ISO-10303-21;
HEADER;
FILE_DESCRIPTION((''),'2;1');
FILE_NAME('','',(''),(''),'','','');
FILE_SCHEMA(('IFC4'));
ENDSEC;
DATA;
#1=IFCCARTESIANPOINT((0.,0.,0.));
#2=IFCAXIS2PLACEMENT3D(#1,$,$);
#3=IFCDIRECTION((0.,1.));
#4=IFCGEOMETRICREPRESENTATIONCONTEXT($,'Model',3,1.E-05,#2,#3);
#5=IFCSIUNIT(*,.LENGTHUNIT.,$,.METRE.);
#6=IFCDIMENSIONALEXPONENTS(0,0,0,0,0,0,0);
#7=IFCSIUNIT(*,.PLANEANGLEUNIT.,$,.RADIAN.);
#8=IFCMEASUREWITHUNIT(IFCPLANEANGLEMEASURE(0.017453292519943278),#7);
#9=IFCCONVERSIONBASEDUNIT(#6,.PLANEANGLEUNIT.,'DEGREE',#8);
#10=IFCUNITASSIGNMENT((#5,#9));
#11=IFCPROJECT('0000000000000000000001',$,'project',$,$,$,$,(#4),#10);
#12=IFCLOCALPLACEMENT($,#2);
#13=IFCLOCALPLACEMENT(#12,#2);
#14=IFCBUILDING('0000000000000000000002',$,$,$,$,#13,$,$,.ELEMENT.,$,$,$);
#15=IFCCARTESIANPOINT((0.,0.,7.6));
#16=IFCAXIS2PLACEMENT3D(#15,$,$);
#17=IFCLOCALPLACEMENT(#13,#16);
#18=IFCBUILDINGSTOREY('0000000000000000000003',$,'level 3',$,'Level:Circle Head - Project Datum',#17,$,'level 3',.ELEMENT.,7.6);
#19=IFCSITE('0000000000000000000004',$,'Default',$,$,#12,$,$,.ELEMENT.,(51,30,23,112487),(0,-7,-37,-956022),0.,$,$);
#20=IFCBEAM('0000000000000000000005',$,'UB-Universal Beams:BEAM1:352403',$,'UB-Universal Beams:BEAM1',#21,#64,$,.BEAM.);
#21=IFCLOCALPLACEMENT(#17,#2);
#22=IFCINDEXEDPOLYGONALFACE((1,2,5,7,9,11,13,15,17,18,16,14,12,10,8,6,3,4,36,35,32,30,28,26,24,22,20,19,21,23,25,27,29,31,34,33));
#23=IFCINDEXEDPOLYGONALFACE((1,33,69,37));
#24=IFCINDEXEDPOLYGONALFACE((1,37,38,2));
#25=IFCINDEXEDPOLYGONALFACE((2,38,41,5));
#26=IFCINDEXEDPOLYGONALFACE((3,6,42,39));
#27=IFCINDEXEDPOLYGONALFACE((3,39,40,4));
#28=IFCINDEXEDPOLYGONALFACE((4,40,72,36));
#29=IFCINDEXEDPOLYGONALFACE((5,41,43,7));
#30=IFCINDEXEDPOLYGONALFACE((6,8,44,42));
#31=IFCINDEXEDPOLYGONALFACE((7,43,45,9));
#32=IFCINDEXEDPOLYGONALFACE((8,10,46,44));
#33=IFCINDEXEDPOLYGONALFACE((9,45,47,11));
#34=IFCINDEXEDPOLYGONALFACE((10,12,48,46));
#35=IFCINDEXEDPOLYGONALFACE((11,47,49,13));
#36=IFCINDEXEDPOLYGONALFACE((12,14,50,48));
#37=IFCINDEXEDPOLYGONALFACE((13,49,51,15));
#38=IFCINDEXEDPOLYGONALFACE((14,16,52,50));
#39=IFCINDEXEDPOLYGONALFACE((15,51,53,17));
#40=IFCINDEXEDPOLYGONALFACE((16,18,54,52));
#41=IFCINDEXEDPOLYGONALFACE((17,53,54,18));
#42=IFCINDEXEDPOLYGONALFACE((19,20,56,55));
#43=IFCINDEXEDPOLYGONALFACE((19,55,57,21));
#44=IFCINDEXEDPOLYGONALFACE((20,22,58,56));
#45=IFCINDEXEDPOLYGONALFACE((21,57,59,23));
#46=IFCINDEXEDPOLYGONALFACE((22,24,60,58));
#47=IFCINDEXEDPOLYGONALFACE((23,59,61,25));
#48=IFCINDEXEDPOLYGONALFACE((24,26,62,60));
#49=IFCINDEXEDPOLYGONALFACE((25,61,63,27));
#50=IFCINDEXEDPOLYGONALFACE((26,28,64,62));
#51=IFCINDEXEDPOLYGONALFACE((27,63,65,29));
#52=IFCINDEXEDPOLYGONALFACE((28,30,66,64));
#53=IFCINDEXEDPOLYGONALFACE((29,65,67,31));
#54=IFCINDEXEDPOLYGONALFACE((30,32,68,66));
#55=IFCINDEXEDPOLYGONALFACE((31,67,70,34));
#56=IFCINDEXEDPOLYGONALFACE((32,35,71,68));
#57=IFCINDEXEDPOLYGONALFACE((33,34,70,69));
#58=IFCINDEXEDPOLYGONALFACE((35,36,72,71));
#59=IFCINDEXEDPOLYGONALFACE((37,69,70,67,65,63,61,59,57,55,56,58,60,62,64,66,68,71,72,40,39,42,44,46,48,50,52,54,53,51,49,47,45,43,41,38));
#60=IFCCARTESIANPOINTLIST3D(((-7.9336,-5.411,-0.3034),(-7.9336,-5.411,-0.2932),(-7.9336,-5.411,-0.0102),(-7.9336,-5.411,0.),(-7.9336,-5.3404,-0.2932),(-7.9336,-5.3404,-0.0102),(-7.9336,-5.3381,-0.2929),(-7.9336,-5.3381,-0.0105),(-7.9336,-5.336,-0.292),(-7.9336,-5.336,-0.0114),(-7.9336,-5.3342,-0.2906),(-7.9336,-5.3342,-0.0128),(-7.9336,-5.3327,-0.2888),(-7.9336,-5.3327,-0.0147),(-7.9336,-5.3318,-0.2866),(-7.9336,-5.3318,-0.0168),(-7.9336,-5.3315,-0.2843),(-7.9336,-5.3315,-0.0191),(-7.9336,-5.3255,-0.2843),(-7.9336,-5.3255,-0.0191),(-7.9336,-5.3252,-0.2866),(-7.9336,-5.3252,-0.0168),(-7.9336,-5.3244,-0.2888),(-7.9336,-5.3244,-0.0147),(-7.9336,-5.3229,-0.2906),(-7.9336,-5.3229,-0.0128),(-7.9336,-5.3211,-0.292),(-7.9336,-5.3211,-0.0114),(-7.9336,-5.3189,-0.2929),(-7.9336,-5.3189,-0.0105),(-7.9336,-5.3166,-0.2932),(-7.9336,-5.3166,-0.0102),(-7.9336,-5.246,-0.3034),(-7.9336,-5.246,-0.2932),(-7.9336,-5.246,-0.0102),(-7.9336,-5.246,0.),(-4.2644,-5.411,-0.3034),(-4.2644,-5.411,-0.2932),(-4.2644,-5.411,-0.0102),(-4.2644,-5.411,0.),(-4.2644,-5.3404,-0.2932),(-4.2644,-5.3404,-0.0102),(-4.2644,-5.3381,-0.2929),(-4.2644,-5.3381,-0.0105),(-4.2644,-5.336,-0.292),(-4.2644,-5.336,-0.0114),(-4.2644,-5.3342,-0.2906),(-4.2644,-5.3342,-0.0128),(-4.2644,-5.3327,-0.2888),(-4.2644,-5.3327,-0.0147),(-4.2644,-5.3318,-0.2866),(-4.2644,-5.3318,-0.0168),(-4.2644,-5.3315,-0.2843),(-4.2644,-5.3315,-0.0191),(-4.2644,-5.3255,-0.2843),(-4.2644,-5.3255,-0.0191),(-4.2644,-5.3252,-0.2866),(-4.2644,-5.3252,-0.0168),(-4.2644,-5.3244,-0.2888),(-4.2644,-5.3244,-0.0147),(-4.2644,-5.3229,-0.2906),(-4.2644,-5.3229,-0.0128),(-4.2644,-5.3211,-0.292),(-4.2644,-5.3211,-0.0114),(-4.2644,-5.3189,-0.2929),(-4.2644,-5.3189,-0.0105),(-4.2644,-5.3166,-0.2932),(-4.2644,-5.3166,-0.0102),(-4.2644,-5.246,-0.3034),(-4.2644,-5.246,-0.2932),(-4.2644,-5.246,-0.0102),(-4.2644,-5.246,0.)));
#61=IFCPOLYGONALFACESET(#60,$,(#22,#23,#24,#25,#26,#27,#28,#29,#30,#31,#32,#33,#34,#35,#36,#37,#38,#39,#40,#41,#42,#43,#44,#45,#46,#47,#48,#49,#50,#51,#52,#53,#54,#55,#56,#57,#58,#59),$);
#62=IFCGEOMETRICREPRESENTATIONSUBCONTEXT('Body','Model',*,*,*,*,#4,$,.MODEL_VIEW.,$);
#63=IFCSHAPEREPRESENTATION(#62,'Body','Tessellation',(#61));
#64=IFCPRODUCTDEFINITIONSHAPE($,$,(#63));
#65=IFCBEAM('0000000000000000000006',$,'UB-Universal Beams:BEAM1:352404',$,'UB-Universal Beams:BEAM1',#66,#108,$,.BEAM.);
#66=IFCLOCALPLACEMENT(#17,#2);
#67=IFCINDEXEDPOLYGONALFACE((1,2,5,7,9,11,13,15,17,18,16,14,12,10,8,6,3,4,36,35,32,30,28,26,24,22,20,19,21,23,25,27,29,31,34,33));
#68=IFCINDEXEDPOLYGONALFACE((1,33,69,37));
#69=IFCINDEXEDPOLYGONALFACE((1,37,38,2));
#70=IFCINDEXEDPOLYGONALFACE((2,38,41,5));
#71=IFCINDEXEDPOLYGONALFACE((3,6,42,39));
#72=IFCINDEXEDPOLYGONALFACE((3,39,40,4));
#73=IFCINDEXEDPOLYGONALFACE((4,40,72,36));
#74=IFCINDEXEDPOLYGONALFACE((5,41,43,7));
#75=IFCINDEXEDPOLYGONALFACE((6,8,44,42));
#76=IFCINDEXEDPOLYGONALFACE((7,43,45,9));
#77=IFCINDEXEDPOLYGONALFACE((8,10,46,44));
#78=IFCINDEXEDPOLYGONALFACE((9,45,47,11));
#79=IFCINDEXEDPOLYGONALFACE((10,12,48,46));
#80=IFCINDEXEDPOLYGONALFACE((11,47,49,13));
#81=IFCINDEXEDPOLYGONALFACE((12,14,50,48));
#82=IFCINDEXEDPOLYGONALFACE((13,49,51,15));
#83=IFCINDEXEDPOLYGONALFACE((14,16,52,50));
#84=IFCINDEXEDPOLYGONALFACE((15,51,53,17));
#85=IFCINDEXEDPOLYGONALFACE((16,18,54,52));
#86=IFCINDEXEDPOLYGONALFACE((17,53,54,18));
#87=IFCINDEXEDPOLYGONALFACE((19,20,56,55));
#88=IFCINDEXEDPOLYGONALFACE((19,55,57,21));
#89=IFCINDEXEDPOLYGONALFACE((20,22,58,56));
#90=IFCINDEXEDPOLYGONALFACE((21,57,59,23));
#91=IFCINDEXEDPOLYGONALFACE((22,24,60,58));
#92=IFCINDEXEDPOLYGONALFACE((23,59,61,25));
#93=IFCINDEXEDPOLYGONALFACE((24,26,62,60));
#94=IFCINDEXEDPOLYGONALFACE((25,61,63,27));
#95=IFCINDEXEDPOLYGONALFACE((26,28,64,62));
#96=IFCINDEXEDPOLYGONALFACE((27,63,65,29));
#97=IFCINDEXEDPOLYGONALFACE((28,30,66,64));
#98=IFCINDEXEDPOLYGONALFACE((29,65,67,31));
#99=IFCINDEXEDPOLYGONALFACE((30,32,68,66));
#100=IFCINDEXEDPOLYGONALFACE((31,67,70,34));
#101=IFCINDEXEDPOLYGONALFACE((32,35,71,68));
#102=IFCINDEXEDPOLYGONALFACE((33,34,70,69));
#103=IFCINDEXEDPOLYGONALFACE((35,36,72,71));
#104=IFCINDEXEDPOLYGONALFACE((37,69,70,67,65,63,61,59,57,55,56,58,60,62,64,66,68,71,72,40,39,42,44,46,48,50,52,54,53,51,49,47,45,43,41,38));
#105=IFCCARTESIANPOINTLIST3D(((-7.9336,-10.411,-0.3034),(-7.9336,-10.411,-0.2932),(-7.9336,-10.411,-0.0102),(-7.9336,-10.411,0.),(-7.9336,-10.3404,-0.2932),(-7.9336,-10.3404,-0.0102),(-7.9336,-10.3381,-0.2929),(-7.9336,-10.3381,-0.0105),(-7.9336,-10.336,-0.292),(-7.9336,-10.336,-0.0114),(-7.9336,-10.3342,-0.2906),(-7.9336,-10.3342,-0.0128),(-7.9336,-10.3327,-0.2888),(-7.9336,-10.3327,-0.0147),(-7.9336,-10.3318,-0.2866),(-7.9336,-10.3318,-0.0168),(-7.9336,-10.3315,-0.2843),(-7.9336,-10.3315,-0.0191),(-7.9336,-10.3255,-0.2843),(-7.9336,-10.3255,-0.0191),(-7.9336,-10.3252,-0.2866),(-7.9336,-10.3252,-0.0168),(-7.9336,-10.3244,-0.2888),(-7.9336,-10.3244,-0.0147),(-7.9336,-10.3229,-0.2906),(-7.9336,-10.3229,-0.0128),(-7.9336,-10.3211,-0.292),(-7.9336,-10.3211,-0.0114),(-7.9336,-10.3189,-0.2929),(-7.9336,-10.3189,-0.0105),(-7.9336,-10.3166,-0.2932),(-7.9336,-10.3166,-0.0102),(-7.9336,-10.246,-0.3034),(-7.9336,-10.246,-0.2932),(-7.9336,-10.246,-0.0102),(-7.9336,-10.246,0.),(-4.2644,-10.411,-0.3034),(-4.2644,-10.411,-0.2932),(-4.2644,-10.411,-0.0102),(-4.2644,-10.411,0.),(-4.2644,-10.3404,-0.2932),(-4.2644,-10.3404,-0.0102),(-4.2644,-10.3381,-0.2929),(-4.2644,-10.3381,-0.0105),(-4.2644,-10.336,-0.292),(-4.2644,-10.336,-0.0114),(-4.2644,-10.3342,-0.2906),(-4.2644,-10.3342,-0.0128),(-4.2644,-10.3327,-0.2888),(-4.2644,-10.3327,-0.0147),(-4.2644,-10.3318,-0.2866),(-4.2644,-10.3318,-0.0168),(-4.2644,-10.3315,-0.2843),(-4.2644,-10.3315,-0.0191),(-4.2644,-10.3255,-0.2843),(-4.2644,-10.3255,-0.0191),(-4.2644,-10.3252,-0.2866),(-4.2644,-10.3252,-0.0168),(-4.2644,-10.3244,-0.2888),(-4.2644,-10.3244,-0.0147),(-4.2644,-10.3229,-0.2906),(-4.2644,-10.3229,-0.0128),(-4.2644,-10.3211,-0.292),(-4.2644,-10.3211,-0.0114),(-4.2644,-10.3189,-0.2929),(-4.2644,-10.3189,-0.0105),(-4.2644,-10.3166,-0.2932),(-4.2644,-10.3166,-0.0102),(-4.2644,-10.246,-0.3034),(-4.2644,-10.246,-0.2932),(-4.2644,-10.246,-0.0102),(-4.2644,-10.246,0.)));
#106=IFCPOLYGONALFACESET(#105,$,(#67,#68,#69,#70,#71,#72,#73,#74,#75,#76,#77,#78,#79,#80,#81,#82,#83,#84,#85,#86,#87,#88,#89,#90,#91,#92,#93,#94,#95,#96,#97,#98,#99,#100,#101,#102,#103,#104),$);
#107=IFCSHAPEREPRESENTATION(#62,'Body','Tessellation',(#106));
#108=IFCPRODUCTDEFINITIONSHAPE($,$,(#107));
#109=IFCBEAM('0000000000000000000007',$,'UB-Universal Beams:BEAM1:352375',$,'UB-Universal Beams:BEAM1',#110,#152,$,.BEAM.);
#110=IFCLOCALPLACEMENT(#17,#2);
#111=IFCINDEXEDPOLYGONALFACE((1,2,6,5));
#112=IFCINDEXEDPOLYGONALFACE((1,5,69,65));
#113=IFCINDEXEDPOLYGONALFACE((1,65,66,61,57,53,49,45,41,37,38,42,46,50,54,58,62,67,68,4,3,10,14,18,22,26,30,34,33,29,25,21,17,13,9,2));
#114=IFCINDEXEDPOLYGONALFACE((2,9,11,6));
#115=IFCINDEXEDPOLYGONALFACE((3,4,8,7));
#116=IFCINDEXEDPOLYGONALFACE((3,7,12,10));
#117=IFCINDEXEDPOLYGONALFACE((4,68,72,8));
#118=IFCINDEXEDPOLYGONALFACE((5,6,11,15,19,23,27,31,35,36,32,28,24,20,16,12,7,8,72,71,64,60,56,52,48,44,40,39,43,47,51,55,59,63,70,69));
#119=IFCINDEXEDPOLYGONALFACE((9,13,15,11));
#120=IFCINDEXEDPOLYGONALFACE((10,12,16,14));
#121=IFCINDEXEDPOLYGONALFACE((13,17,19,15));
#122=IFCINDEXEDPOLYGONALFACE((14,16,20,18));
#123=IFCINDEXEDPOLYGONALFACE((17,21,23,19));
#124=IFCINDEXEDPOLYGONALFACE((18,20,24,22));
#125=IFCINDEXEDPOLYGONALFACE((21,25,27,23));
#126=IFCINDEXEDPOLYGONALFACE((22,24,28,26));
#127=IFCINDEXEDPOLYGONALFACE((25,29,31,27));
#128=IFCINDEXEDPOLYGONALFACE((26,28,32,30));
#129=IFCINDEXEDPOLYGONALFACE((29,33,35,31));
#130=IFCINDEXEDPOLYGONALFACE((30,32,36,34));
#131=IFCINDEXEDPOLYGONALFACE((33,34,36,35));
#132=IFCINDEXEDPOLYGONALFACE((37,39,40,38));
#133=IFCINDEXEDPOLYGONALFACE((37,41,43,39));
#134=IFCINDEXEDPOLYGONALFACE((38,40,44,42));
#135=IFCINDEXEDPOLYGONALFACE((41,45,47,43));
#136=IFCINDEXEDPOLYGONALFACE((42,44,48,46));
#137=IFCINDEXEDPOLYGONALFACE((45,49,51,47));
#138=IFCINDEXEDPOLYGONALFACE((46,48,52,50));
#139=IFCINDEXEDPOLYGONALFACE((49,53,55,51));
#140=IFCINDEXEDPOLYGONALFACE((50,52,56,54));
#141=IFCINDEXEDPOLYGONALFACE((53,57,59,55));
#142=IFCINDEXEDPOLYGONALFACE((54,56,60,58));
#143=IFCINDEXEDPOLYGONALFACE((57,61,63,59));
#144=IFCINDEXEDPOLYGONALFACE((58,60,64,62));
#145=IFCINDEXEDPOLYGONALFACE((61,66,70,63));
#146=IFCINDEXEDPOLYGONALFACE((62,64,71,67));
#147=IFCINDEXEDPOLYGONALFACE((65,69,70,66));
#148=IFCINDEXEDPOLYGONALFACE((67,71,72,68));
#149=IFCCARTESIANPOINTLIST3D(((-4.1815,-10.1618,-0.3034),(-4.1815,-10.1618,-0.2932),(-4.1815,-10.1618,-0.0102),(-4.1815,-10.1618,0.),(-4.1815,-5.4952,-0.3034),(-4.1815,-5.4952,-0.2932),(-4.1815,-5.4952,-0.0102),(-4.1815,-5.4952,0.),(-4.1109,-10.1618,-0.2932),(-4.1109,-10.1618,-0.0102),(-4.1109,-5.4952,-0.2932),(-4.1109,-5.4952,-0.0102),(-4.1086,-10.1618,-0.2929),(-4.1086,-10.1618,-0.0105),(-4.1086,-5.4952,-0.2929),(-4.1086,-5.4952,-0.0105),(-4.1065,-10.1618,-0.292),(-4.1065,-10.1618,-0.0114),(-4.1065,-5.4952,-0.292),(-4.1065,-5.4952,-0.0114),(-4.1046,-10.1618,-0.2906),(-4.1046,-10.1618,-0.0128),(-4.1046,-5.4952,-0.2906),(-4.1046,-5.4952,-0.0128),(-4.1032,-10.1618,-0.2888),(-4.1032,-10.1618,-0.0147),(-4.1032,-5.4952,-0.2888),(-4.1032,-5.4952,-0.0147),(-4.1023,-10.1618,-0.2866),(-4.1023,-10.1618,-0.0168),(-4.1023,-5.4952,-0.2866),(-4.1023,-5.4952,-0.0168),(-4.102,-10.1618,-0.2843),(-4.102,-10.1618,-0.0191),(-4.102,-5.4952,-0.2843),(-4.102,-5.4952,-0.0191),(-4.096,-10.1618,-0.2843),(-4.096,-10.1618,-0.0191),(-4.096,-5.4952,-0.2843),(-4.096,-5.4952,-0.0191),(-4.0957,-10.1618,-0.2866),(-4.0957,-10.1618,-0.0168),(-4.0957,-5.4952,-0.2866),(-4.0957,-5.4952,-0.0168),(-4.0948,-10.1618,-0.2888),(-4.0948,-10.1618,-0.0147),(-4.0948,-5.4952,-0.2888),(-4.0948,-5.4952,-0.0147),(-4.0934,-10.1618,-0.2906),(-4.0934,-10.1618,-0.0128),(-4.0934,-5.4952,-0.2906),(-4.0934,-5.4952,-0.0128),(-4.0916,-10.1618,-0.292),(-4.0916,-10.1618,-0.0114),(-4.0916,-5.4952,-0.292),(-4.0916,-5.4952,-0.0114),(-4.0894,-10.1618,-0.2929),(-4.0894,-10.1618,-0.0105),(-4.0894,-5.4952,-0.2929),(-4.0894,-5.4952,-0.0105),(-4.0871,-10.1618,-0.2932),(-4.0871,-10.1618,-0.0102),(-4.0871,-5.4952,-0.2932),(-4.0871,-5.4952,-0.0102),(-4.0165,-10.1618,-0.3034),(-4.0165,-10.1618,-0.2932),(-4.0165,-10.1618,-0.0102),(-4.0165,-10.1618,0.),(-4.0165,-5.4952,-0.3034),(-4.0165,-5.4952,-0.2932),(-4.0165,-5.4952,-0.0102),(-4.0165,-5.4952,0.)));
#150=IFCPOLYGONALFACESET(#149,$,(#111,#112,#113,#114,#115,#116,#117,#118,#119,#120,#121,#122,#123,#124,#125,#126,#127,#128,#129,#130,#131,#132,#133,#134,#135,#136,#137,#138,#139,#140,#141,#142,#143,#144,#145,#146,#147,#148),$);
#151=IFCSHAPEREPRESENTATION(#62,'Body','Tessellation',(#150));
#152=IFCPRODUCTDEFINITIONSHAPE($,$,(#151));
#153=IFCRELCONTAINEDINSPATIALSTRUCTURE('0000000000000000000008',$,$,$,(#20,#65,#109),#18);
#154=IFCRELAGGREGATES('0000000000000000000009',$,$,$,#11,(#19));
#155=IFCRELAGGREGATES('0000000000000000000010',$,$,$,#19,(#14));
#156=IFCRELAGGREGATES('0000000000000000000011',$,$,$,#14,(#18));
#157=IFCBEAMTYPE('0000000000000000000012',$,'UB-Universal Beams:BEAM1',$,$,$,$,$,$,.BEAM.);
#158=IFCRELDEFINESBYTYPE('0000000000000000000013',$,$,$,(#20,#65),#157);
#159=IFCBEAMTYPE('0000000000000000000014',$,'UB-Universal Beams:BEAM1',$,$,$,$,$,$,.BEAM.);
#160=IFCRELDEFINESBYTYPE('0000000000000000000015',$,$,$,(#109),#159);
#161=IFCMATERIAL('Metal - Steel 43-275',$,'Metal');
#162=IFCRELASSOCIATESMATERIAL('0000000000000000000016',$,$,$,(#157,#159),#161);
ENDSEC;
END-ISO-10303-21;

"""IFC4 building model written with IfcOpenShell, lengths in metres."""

from ifc_helpers import new_model, entity, si_unit, converted_unit, direction, frame, frame_2d, origin, place, context, subcontext, project, spatial, polyline, circle_curve, parameter, trimmed, segment, composite_curve, outline, extrude, source, transform, mapped, material, material_profile, profile_set, type_object, type_shapes, element, save


model = new_model("IFC4")

# Units and contexts
model_context = context("Model", 3, precision=1e-05, world=origin(), true_north=direction((0.0, 1.0)))
body_context = subcontext(model_context, "Body", "Model", "MODEL_VIEW")
ifc_project = project(units=[si_unit("LENGTHUNIT", "METRE"), converted_unit("PLANEANGLEUNIT", "DEGREE", entity("IfcPlaneAngleMeasure", 0.017453292519943278), si_unit("PLANEANGLEUNIT", "RADIAN"), dimensions=[0, 0, 0, 0, 0, 0, 0])], contexts=[model_context])

# Site, building, storey
site_placement = place(None, origin())
site = spatial("IfcSite", under=ifc_project, at=site_placement, Name="Default", CompositionType="ELEMENT", RefLatitude=(51, 30, 23, 112487), RefLongitude=(0, -7, -37, -956022), RefElevation=0.0)
building_placement = place(site_placement, origin())
building = spatial("IfcBuilding", under=site, at=building_placement, CompositionType="ELEMENT")
storey_placement = place(building_placement, frame((0.0, 0.0, 7.6)))
storey = spatial("IfcBuildingStorey", under=building, at=storey_placement, Name="level 3", ObjectType="Level:Circle Head - Project Datum", LongName="level 3", CompositionType="ELEMENT", Elevation=7.6)

# Shared definitions
ifc_material_1 = material(Name="Metal - Steel 43-275", Category="Metal")

# Beams
ifc_material_profile_1 = material_profile(ifc_material_1, outline(composite_curve([segment(polyline([(-0.0825, -0.1415), (-0.0825, -0.1517)]), True, "CONTINUOUS"), segment(polyline([(-0.0825, -0.1517), (0.0825, -0.1517)]), True, "CONTINUOUS"), segment(polyline([(0.0825, -0.1517), (0.0825, -0.1415)]), True, "CONTINUOUS"), segment(polyline([(0.0825, -0.1415), (0.0119, -0.1415)]), True, "CONTINUOUS"), segment(trimmed(circle_curve(frame_2d((0.0119, -0.1326), x_axis=(1.0, 0.0)), 0.0089), [parameter(180.0)], [parameter(270.0)], True, "PARAMETER"), False, "CONTINUOUS"), segment(polyline([(0.003, -0.1326), (0.003, 0.1326)]), True, "CONTINUOUS"), segment(trimmed(circle_curve(frame_2d((0.0119, 0.1326), x_axis=(1.0, 0.0)), 0.0089), [parameter(90.0)], [parameter(180.0)], True, "PARAMETER"), False, "CONTINUOUS"), segment(polyline([(0.0119, 0.1415), (0.0825, 0.1415)]), True, "CONTINUOUS"), segment(polyline([(0.0825, 0.1415), (0.0825, 0.1517)]), True, "CONTINUOUS"), segment(polyline([(0.0825, 0.1517), (-0.0825, 0.1517)]), True, "CONTINUOUS"), segment(polyline([(-0.0825, 0.1517), (-0.0825, 0.1415)]), True, "CONTINUOUS"), segment(polyline([(-0.0825, 0.1415), (-0.0119, 0.1415)]), True, "CONTINUOUS"), segment(trimmed(circle_curve(frame_2d((-0.0119, 0.1326), x_axis=(1.0, 0.0)), 0.0089), [parameter(360.0)], [parameter(90.0)], True, "PARAMETER"), False, "CONTINUOUS"), segment(polyline([(-0.003, 0.1326), (-0.003, -0.1326)]), True, "CONTINUOUS"), segment(trimmed(circle_curve(frame_2d((-0.0119, -0.1326), x_axis=(1.0, 0.0)), 0.0089), [parameter(270.0)], [parameter(360.0)], True, "PARAMETER"), False, "CONTINUOUS"), segment(polyline([(-0.0119, -0.1415), (-0.0825, -0.1415)]), True, "CONTINUOUS")], self_intersect=False)), Name="BEAM1")
ifc_profile_set_1 = profile_set([ifc_material_profile_1], Name="BEAM1")
beam_type_1 = type_object("IfcBeamType", Name="UB-Universal Beams:BEAM1", PredefinedType="BEAM", material=ifc_profile_set_1)
shared_shape_1 = source(origin(), body_context, "Body", "SweptSolid", [
    extrude(outline(composite_curve([segment(polyline([(-0.0825, -0.1415), (-0.0825, -0.1517)]), True, "CONTINUOUS"), segment(polyline([(-0.0825, -0.1517), (0.0825, -0.1517)]), True, "CONTINUOUS"), segment(polyline([(0.0825, -0.1517), (0.0825, -0.1415)]), True, "CONTINUOUS"), segment(polyline([(0.0825, -0.1415), (0.0119, -0.1415)]), True, "CONTINUOUS"), segment(trimmed(circle_curve(frame_2d((0.0119, -0.1326), x_axis=(0.0, -1.0)), 0.0089), [parameter(270.0)], [parameter(360.0)], True, "PARAMETER"), False, "CONTINUOUS"), segment(polyline([(0.003, -0.1326), (0.003, 0.1326)]), True, "CONTINUOUS"), segment(trimmed(circle_curve(frame_2d((0.0119, 0.1326), x_axis=(-1.0, 0.0)), 0.0089), [parameter(270.0)], [parameter(360.0)], True, "PARAMETER"), False, "CONTINUOUS"), segment(polyline([(0.0119, 0.1415), (0.0825, 0.1415)]), True, "CONTINUOUS"), segment(polyline([(0.0825, 0.1415), (0.0825, 0.1517)]), True, "CONTINUOUS"), segment(polyline([(0.0825, 0.1517), (-0.0825, 0.1517)]), True, "CONTINUOUS"), segment(polyline([(-0.0825, 0.1517), (-0.0825, 0.1415)]), True, "CONTINUOUS"), segment(polyline([(-0.0825, 0.1415), (-0.0119, 0.1415)]), True, "CONTINUOUS"), segment(trimmed(circle_curve(frame_2d((-0.0119, 0.1326), x_axis=(0.0, 1.0)), 0.0089), [parameter(270.0)], [parameter(360.0)], True, "PARAMETER"), False, "CONTINUOUS"), segment(polyline([(-0.003, 0.1326), (-0.003, -0.1326)]), True, "CONTINUOUS"), segment(trimmed(circle_curve(frame_2d((-0.0119, -0.1326), x_axis=(1.0, 0.0)), 0.0089), [parameter(270.0)], [parameter(0.0)], True, "PARAMETER"), False, "CONTINUOUS"), segment(polyline([(-0.0119, -0.1415), (-0.0825, -0.1415)]), True, "CONTINUOUS")], self_intersect=False)), frame((-1.8346, 0.0, 0.0), z_axis=(-1.0, 0.0, 0.0), x_axis=(0.0, -1.0, 0.0)), (0.0, 0.0, -1.0), 3.6692),
])
type_shapes(beam_type_1, [shared_shape_1])
for number, where, name in (
    (1, (-6.099, -5.3285, -0.1517), "UB-Universal Beams:BEAM1:352403"),
    (2, (-6.099, -10.3285, -0.1517), "UB-Universal Beams:BEAM1:352404"),
):
    element("IfcBeam", number, at=place(storey_placement, frame(where)), inside=storey, type_object=beam_type_1, Name=name, ObjectType="UB-Universal Beams:BEAM1", PredefinedType="BEAM", context=body_context, shape_type="MappedRepresentation", body=[
        mapped(shared_shape_1, transform((0.0, 0.0, 0.0), scale=1.0)),
    ])
beam_type_2 = type_object("IfcBeamType", Name="UB-Universal Beams:BEAM1", PredefinedType="BEAM", material=ifc_profile_set_1)
shared_shape_2 = source(origin(), body_context, "Body", "SweptSolid", [
    extrude(outline(composite_curve([segment(polyline([(-0.0825, -0.1415), (-0.0825, -0.1517)]), True, "CONTINUOUS"), segment(polyline([(-0.0825, -0.1517), (0.0825, -0.1517)]), True, "CONTINUOUS"), segment(polyline([(0.0825, -0.1517), (0.0825, -0.1415)]), True, "CONTINUOUS"), segment(polyline([(0.0825, -0.1415), (0.0119, -0.1415)]), True, "CONTINUOUS"), segment(trimmed(circle_curve(frame_2d((0.0119, -0.1326), x_axis=(0.0, -1.0)), 0.0089), [parameter(270.0)], [parameter(360.0)], True, "PARAMETER"), False, "CONTINUOUS"), segment(polyline([(0.003, -0.1326), (0.003, 0.1326)]), True, "CONTINUOUS"), segment(trimmed(circle_curve(frame_2d((0.0119, 0.1326), x_axis=(-1.0, 0.0)), 0.0089), [parameter(270.0)], [parameter(360.0)], True, "PARAMETER"), False, "CONTINUOUS"), segment(polyline([(0.0119, 0.1415), (0.0825, 0.1415)]), True, "CONTINUOUS"), segment(polyline([(0.0825, 0.1415), (0.0825, 0.1517)]), True, "CONTINUOUS"), segment(polyline([(0.0825, 0.1517), (-0.0825, 0.1517)]), True, "CONTINUOUS"), segment(polyline([(-0.0825, 0.1517), (-0.0825, 0.1415)]), True, "CONTINUOUS"), segment(polyline([(-0.0825, 0.1415), (-0.0119, 0.1415)]), True, "CONTINUOUS"), segment(trimmed(circle_curve(frame_2d((-0.0119, 0.1326), x_axis=(0.0, 1.0)), 0.0089), [parameter(270.0)], [parameter(360.0)], True, "PARAMETER"), False, "CONTINUOUS"), segment(polyline([(-0.003, 0.1326), (-0.003, -0.1326)]), True, "CONTINUOUS"), segment(trimmed(circle_curve(frame_2d((-0.0119, -0.1326), x_axis=(1.0, 0.0)), 0.0089), [parameter(270.0)], [parameter(0.0)], True, "PARAMETER"), False, "CONTINUOUS"), segment(polyline([(-0.0119, -0.1415), (-0.0825, -0.1415)]), True, "CONTINUOUS")], self_intersect=False)), frame((-2.3333, 0.0, 0.0), z_axis=(-1.0, 0.0, 0.0), x_axis=(0.0, -1.0, 0.0)), (0.0, 0.0, -1.0), 4.6666),
])
type_shapes(beam_type_2, [shared_shape_2])
for number, where, z_axis, x_axis, name in (
    (3, (-4.099, -7.8285, -0.1517), (0.0, 0.0, 1.0), (0.0, 1.0, 0.0), "UB-Universal Beams:BEAM1:352375"),
):
    element("IfcBeam", number, at=place(storey_placement, frame(where, z_axis=z_axis, x_axis=x_axis)), inside=storey, type_object=beam_type_2, Name=name, ObjectType="UB-Universal Beams:BEAM1", PredefinedType="BEAM", context=body_context, shape_type="MappedRepresentation", body=[
        mapped(shared_shape_2, transform((0.0, 0.0, 0.0), scale=1.0)),
    ])

save(model, "model.ifc")
